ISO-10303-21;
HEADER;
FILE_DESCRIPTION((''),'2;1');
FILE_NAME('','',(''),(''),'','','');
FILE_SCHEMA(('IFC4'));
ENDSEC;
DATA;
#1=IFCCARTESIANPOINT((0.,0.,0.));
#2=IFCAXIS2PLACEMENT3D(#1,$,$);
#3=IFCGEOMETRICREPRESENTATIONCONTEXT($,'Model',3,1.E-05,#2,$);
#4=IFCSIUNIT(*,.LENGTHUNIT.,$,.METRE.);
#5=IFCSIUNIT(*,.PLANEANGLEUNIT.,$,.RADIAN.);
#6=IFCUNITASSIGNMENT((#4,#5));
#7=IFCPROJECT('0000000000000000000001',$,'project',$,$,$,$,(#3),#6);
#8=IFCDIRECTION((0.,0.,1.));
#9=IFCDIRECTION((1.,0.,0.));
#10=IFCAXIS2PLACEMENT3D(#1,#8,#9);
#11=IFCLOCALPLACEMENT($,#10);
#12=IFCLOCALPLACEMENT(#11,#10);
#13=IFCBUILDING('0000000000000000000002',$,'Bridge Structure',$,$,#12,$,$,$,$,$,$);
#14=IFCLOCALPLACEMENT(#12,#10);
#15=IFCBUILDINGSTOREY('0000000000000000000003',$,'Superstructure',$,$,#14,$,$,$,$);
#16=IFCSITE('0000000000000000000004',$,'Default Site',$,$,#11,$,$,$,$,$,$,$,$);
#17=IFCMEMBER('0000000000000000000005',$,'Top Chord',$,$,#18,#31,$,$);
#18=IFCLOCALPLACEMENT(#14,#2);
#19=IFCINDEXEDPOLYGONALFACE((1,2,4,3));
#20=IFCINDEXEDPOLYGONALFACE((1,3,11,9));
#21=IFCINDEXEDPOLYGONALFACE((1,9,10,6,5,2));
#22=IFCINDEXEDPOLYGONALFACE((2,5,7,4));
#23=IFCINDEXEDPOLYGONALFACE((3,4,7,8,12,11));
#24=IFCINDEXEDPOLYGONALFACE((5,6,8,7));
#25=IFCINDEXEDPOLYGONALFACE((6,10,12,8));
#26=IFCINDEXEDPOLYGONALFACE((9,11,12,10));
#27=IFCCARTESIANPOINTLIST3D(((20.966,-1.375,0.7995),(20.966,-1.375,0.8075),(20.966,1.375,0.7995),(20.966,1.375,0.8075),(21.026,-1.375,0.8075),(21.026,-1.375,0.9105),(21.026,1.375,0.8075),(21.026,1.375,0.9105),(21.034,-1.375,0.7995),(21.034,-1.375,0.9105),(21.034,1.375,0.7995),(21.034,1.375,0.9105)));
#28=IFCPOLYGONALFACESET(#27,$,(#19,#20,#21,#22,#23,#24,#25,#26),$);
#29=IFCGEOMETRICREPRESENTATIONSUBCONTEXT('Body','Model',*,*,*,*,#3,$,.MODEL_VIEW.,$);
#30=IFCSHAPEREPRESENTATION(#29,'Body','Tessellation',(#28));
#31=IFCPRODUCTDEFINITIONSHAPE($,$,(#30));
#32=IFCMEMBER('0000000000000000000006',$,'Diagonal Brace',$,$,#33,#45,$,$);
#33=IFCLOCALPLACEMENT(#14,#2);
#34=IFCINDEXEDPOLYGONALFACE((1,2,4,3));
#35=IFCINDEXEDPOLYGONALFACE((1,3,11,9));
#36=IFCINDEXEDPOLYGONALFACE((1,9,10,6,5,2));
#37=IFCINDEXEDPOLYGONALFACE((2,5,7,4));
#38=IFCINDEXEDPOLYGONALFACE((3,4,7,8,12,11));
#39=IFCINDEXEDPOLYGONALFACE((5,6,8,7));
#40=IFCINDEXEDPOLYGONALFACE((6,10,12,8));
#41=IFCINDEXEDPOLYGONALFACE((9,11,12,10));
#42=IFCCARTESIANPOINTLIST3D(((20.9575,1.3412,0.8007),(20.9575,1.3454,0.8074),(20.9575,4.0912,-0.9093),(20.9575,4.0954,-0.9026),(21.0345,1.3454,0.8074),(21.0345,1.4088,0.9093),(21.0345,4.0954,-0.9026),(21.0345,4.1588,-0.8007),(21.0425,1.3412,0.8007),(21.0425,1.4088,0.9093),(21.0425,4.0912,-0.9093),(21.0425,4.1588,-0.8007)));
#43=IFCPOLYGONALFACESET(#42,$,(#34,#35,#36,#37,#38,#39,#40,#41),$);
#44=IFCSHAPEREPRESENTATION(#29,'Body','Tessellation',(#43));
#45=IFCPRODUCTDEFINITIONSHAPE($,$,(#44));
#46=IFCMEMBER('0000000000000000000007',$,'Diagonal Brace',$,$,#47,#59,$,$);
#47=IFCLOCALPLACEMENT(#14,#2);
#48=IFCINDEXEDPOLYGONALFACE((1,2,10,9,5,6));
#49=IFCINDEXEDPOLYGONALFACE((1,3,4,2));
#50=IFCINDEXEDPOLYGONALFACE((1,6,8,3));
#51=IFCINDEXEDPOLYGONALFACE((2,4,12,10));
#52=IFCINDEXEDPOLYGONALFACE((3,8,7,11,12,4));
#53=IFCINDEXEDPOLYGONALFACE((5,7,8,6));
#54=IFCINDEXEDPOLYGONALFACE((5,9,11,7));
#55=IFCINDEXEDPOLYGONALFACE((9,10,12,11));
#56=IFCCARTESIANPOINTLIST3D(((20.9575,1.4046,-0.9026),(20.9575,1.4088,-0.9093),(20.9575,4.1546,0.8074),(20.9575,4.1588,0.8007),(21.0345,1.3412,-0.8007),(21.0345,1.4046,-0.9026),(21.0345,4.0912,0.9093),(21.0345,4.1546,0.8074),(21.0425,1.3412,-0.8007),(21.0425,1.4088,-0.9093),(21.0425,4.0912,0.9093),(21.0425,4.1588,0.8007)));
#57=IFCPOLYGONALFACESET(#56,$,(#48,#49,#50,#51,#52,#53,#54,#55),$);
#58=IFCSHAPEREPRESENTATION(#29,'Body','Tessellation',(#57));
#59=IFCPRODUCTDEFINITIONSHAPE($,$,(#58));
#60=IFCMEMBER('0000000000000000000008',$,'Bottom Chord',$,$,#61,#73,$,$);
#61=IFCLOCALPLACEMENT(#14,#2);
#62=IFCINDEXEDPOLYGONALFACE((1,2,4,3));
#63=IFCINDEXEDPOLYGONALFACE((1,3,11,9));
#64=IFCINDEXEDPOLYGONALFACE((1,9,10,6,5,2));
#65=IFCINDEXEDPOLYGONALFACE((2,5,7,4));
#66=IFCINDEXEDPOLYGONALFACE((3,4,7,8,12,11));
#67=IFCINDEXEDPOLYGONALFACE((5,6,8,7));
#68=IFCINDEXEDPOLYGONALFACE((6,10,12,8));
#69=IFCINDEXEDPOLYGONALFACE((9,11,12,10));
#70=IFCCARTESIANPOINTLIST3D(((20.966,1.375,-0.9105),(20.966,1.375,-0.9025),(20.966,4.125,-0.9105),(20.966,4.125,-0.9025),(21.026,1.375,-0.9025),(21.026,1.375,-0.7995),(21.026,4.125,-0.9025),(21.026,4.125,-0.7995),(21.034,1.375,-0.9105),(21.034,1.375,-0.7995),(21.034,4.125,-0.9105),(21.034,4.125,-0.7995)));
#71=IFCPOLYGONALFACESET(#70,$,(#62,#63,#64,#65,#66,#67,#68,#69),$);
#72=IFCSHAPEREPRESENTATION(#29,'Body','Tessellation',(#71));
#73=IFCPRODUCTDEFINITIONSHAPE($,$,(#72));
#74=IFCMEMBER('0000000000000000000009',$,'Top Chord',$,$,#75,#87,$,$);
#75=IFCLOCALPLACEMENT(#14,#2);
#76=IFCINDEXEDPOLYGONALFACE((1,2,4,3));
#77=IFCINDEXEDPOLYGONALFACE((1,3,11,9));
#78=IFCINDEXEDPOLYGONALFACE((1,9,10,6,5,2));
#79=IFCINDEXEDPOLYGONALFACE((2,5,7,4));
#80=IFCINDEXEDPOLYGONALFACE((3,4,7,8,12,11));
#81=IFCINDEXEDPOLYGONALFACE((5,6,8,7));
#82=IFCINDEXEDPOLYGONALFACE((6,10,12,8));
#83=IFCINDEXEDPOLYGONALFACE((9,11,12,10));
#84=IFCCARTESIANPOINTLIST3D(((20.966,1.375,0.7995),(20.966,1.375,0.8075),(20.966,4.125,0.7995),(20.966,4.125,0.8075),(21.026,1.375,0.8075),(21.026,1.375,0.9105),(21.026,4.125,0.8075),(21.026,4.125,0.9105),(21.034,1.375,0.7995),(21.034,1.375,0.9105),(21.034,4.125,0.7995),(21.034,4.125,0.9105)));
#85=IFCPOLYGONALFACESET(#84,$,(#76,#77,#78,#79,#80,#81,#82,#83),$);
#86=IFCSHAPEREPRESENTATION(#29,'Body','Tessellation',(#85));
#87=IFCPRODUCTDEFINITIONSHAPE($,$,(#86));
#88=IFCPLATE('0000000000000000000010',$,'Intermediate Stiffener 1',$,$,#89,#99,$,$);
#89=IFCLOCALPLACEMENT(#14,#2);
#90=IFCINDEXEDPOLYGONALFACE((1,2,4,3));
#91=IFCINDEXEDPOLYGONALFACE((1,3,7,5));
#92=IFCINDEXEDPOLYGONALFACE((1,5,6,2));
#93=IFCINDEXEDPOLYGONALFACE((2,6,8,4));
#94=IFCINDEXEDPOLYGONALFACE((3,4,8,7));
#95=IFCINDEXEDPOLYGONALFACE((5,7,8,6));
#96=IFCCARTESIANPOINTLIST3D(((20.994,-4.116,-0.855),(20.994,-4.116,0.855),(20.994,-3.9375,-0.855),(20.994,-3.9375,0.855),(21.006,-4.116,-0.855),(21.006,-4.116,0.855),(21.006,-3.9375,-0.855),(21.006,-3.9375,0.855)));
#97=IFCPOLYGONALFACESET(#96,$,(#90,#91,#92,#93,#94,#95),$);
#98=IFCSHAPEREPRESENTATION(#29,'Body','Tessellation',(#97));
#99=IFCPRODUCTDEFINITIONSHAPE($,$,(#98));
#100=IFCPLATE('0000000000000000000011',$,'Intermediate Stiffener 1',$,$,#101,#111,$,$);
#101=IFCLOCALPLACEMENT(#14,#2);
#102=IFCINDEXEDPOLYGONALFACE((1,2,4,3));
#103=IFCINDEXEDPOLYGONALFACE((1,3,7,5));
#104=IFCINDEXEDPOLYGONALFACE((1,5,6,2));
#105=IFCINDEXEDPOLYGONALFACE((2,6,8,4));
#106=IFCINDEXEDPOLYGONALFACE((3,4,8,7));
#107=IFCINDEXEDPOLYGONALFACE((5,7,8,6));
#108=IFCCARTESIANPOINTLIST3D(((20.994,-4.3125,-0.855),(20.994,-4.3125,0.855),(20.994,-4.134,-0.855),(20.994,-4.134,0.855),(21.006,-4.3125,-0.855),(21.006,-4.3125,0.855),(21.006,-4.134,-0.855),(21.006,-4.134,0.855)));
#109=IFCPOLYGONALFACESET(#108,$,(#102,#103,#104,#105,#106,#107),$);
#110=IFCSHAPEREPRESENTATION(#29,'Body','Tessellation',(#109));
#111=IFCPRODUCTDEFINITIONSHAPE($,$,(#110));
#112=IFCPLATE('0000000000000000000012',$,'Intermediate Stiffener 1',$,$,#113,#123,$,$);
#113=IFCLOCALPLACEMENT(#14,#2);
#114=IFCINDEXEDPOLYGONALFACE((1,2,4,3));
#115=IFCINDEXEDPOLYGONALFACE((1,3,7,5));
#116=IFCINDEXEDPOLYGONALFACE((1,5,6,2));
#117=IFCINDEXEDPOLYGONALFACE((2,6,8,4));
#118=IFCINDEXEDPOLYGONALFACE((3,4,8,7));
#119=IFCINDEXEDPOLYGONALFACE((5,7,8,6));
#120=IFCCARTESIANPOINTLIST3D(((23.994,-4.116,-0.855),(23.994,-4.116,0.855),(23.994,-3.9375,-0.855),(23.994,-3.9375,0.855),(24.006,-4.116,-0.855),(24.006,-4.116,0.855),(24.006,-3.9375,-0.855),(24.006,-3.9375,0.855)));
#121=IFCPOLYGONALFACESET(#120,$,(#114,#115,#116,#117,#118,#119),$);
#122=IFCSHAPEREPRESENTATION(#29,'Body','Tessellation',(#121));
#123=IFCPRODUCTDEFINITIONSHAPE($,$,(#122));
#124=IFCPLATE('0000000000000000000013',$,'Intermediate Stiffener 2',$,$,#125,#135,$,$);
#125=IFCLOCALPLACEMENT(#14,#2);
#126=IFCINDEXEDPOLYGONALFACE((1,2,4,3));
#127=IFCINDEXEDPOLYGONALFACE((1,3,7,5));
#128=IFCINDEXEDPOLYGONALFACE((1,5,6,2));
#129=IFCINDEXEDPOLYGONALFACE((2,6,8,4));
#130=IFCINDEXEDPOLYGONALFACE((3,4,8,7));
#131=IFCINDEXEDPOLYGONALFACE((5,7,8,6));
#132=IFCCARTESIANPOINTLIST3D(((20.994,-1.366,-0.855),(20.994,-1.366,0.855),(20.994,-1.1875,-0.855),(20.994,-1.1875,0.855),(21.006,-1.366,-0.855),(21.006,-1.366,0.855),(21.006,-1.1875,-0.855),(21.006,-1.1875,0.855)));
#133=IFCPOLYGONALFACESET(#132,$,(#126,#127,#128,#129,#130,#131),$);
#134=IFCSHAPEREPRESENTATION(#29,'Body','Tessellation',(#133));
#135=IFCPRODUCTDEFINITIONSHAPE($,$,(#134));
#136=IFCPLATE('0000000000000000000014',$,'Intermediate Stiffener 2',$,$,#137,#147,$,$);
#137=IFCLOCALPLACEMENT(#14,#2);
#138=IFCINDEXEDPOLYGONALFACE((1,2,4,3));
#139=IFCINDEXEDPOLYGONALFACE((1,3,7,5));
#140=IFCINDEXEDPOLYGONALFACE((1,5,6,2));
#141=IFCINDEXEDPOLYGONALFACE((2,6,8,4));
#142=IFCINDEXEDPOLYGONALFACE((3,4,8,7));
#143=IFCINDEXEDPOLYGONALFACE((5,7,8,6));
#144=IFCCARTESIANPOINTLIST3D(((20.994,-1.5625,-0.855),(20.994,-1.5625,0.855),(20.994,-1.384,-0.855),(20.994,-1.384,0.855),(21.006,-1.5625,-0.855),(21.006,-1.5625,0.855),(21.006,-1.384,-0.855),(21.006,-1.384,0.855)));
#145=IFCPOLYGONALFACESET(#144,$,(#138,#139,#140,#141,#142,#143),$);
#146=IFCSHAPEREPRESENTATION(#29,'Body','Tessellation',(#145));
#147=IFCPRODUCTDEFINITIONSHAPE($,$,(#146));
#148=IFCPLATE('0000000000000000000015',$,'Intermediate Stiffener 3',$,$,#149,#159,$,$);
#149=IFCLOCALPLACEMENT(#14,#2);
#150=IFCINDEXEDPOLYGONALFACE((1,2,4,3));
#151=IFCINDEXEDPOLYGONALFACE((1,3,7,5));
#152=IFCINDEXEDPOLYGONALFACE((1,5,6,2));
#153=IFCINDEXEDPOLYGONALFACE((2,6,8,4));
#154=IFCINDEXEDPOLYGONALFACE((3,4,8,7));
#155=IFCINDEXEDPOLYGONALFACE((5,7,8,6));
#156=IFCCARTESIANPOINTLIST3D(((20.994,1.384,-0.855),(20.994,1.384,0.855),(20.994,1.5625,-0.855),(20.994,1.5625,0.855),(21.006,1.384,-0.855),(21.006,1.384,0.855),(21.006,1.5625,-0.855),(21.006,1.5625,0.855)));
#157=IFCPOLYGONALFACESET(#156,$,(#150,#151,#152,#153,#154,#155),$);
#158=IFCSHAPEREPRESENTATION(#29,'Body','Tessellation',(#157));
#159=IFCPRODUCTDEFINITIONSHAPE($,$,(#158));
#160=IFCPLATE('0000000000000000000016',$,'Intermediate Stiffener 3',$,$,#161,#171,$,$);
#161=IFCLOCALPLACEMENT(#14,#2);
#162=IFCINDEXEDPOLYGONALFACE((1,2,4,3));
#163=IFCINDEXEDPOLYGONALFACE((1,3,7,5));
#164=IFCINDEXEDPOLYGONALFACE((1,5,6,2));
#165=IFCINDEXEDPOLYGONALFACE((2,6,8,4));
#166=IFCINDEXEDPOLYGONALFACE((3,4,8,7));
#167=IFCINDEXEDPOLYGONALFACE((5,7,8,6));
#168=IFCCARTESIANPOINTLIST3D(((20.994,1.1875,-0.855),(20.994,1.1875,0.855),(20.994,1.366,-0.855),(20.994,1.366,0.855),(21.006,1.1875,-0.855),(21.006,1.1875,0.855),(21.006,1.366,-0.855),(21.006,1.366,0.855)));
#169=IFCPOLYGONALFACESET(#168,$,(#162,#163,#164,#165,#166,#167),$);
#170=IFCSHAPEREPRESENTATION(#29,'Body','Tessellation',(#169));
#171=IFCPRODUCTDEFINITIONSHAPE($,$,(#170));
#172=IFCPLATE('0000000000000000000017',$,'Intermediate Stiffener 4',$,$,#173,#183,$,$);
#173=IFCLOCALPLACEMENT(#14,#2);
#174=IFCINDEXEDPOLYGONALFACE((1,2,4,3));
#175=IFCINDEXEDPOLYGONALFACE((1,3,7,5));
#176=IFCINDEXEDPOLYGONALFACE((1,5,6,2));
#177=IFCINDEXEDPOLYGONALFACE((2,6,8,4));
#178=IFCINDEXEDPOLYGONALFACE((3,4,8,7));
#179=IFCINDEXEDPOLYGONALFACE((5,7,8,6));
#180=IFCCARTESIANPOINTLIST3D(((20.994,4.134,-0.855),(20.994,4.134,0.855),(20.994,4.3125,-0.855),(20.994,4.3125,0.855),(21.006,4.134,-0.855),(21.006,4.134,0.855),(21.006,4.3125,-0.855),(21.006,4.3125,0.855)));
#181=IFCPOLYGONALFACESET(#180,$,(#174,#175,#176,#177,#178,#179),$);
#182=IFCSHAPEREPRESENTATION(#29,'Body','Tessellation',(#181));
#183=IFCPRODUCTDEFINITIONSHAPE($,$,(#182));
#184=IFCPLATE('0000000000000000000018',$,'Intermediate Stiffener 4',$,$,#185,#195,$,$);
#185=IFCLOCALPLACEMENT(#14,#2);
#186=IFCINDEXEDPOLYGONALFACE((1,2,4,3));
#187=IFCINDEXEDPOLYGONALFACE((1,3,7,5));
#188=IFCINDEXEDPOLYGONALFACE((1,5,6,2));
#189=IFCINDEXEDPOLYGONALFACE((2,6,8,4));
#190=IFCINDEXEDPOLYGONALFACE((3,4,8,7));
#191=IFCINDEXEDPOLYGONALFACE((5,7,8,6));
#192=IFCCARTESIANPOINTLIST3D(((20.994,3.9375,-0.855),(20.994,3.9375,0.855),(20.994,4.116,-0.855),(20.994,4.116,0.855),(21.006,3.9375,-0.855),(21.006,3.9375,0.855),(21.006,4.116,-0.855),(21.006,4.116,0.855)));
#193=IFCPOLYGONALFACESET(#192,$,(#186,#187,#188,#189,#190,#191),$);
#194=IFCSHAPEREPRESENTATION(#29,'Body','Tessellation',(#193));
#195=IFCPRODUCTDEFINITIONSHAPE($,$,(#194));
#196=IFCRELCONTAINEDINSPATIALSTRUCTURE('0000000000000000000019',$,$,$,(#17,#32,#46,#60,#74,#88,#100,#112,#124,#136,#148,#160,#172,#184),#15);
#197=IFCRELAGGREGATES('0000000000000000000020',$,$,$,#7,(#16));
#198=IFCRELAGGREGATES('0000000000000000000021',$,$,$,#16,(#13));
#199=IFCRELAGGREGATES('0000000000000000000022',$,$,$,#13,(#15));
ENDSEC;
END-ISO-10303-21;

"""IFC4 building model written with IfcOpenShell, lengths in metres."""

from ifc_helpers import new_model, si_unit, frame, origin, origin_with_axes, origin_2d_with_axis, place, context, subcontext, project, spatial, rectangle, l_section, extrude, element, save


model = new_model("IFC4")

# Units and contexts
model_context = context("Model", 3, precision=1e-05, world=origin())
body_context = subcontext(model_context, "Body", "Model", "MODEL_VIEW")
ifc_project = project(units=[si_unit("LENGTHUNIT", "METRE"), si_unit("PLANEANGLEUNIT", "RADIAN")], contexts=[model_context])

# Site, building, storey
site_placement = place(None, origin_with_axes())
site = spatial("IfcSite", under=ifc_project, at=site_placement, Name="Default Site")
building_placement = place(site_placement, origin_with_axes())
building = spatial("IfcBuilding", under=site, at=building_placement, Name="Bridge Structure")
storey_placement = place(building_placement, origin_with_axes())
storey = spatial("IfcBuildingStorey", under=building, at=storey_placement, Name="Superstructure")

# Members
for number, where, z_axis, x_axis, name in (
    (1, (21.0, -1.375, 0.855), (0.0, 1.0, 0.0), (-1.0, 0.0, 0.0), "Top Chord"),
):
    element("IfcMember", number, at=place(storey_placement, frame(where, z_axis=z_axis, x_axis=x_axis)), inside=storey, Name=name, context=body_context, shape_type="SweptSolid", body=[
        extrude(l_section(Depth=0.111, Width=0.068, Thickness=0.008, at=origin_2d_with_axis()), origin_with_axes(), (0.0, 0.0, 1.0), 2.75),
    ])
for number, where, z_axis, x_axis, name in (
    (2, (21.0, 1.375, 0.855), (0.0, 0.84921, -0.528055), (-1.0, 0.0, 0.0), "Diagonal Brace"),
    (3, (21.0, 1.375, -0.855), (0.0, 0.84921, 0.528055), (-1.0, 0.0, 0.0), "Diagonal Brace"),
):
    element("IfcMember", number, at=place(storey_placement, frame(where, z_axis=z_axis, x_axis=x_axis)), inside=storey, Name=name, context=body_context, shape_type="SweptSolid", body=[
        extrude(l_section(Depth=0.128, Width=0.085, Thickness=0.008, at=origin_2d_with_axis()), origin_with_axes(), (0.0, 0.0, 1.0), 3.2383),
    ])
for number, where, z_axis, x_axis, name in (
    (4, (21.0, 1.375, -0.855), (0.0, 1.0, 0.0), (-1.0, 0.0, 0.0), "Bottom Chord"),
    (5, (21.0, 1.375, 0.855), (0.0, 1.0, 0.0), (-1.0, 0.0, 0.0), "Top Chord"),
):
    element("IfcMember", number, at=place(storey_placement, frame(where, z_axis=z_axis, x_axis=x_axis)), inside=storey, Name=name, context=body_context, shape_type="SweptSolid", body=[
        extrude(l_section(Depth=0.111, Width=0.068, Thickness=0.008, at=origin_2d_with_axis()), origin_with_axes(), (0.0, 0.0, 1.0), 2.75),
    ])

# Plates
for number, where, z_axis, x_axis, name in (
    (6, (21.0, -4.0267, -0.855), (0.0, 0.0, 1.0), (1.0, 0.0, 0.0), "Intermediate Stiffener 1"),
    (7, (21.0, -4.2233, -0.855), (0.0, 0.0, 1.0), (1.0, 0.0, 0.0), "Intermediate Stiffener 1"),
    (8, (24.0, -4.0267, -0.855), (0.0, 0.0, 1.0), (1.0, 0.0, 0.0), "Intermediate Stiffener 1"),
    (9, (21.0, -1.2768, -0.855), (0.0, 0.0, 1.0), (1.0, 0.0, 0.0), "Intermediate Stiffener 2"),
    (10, (21.0, -1.4732, -0.855), (0.0, 0.0, 1.0), (1.0, 0.0, 0.0), "Intermediate Stiffener 2"),
    (11, (21.0, 1.4732, -0.855), (0.0, 0.0, 1.0), (1.0, 0.0, 0.0), "Intermediate Stiffener 3"),
    (12, (21.0, 1.2768, -0.855), (0.0, 0.0, 1.0), (1.0, 0.0, 0.0), "Intermediate Stiffener 3"),
    (13, (21.0, 4.2233, -0.855), (0.0, 0.0, 1.0), (1.0, 0.0, 0.0), "Intermediate Stiffener 4"),
    (14, (21.0, 4.0267, -0.855), (0.0, 0.0, 1.0), (1.0, 0.0, 0.0), "Intermediate Stiffener 4"),
):
    element("IfcPlate", number, at=place(storey_placement, frame(where, z_axis=z_axis, x_axis=x_axis)), inside=storey, Name=name, context=body_context, shape_type="SweptSolid", body=[
        extrude(rectangle(XDim=0.012, YDim=0.1785, at=origin_2d_with_axis()), origin_with_axes(), (0.0, 0.0, 1.0), 1.71),
    ])

save(model, "model.ifc")
